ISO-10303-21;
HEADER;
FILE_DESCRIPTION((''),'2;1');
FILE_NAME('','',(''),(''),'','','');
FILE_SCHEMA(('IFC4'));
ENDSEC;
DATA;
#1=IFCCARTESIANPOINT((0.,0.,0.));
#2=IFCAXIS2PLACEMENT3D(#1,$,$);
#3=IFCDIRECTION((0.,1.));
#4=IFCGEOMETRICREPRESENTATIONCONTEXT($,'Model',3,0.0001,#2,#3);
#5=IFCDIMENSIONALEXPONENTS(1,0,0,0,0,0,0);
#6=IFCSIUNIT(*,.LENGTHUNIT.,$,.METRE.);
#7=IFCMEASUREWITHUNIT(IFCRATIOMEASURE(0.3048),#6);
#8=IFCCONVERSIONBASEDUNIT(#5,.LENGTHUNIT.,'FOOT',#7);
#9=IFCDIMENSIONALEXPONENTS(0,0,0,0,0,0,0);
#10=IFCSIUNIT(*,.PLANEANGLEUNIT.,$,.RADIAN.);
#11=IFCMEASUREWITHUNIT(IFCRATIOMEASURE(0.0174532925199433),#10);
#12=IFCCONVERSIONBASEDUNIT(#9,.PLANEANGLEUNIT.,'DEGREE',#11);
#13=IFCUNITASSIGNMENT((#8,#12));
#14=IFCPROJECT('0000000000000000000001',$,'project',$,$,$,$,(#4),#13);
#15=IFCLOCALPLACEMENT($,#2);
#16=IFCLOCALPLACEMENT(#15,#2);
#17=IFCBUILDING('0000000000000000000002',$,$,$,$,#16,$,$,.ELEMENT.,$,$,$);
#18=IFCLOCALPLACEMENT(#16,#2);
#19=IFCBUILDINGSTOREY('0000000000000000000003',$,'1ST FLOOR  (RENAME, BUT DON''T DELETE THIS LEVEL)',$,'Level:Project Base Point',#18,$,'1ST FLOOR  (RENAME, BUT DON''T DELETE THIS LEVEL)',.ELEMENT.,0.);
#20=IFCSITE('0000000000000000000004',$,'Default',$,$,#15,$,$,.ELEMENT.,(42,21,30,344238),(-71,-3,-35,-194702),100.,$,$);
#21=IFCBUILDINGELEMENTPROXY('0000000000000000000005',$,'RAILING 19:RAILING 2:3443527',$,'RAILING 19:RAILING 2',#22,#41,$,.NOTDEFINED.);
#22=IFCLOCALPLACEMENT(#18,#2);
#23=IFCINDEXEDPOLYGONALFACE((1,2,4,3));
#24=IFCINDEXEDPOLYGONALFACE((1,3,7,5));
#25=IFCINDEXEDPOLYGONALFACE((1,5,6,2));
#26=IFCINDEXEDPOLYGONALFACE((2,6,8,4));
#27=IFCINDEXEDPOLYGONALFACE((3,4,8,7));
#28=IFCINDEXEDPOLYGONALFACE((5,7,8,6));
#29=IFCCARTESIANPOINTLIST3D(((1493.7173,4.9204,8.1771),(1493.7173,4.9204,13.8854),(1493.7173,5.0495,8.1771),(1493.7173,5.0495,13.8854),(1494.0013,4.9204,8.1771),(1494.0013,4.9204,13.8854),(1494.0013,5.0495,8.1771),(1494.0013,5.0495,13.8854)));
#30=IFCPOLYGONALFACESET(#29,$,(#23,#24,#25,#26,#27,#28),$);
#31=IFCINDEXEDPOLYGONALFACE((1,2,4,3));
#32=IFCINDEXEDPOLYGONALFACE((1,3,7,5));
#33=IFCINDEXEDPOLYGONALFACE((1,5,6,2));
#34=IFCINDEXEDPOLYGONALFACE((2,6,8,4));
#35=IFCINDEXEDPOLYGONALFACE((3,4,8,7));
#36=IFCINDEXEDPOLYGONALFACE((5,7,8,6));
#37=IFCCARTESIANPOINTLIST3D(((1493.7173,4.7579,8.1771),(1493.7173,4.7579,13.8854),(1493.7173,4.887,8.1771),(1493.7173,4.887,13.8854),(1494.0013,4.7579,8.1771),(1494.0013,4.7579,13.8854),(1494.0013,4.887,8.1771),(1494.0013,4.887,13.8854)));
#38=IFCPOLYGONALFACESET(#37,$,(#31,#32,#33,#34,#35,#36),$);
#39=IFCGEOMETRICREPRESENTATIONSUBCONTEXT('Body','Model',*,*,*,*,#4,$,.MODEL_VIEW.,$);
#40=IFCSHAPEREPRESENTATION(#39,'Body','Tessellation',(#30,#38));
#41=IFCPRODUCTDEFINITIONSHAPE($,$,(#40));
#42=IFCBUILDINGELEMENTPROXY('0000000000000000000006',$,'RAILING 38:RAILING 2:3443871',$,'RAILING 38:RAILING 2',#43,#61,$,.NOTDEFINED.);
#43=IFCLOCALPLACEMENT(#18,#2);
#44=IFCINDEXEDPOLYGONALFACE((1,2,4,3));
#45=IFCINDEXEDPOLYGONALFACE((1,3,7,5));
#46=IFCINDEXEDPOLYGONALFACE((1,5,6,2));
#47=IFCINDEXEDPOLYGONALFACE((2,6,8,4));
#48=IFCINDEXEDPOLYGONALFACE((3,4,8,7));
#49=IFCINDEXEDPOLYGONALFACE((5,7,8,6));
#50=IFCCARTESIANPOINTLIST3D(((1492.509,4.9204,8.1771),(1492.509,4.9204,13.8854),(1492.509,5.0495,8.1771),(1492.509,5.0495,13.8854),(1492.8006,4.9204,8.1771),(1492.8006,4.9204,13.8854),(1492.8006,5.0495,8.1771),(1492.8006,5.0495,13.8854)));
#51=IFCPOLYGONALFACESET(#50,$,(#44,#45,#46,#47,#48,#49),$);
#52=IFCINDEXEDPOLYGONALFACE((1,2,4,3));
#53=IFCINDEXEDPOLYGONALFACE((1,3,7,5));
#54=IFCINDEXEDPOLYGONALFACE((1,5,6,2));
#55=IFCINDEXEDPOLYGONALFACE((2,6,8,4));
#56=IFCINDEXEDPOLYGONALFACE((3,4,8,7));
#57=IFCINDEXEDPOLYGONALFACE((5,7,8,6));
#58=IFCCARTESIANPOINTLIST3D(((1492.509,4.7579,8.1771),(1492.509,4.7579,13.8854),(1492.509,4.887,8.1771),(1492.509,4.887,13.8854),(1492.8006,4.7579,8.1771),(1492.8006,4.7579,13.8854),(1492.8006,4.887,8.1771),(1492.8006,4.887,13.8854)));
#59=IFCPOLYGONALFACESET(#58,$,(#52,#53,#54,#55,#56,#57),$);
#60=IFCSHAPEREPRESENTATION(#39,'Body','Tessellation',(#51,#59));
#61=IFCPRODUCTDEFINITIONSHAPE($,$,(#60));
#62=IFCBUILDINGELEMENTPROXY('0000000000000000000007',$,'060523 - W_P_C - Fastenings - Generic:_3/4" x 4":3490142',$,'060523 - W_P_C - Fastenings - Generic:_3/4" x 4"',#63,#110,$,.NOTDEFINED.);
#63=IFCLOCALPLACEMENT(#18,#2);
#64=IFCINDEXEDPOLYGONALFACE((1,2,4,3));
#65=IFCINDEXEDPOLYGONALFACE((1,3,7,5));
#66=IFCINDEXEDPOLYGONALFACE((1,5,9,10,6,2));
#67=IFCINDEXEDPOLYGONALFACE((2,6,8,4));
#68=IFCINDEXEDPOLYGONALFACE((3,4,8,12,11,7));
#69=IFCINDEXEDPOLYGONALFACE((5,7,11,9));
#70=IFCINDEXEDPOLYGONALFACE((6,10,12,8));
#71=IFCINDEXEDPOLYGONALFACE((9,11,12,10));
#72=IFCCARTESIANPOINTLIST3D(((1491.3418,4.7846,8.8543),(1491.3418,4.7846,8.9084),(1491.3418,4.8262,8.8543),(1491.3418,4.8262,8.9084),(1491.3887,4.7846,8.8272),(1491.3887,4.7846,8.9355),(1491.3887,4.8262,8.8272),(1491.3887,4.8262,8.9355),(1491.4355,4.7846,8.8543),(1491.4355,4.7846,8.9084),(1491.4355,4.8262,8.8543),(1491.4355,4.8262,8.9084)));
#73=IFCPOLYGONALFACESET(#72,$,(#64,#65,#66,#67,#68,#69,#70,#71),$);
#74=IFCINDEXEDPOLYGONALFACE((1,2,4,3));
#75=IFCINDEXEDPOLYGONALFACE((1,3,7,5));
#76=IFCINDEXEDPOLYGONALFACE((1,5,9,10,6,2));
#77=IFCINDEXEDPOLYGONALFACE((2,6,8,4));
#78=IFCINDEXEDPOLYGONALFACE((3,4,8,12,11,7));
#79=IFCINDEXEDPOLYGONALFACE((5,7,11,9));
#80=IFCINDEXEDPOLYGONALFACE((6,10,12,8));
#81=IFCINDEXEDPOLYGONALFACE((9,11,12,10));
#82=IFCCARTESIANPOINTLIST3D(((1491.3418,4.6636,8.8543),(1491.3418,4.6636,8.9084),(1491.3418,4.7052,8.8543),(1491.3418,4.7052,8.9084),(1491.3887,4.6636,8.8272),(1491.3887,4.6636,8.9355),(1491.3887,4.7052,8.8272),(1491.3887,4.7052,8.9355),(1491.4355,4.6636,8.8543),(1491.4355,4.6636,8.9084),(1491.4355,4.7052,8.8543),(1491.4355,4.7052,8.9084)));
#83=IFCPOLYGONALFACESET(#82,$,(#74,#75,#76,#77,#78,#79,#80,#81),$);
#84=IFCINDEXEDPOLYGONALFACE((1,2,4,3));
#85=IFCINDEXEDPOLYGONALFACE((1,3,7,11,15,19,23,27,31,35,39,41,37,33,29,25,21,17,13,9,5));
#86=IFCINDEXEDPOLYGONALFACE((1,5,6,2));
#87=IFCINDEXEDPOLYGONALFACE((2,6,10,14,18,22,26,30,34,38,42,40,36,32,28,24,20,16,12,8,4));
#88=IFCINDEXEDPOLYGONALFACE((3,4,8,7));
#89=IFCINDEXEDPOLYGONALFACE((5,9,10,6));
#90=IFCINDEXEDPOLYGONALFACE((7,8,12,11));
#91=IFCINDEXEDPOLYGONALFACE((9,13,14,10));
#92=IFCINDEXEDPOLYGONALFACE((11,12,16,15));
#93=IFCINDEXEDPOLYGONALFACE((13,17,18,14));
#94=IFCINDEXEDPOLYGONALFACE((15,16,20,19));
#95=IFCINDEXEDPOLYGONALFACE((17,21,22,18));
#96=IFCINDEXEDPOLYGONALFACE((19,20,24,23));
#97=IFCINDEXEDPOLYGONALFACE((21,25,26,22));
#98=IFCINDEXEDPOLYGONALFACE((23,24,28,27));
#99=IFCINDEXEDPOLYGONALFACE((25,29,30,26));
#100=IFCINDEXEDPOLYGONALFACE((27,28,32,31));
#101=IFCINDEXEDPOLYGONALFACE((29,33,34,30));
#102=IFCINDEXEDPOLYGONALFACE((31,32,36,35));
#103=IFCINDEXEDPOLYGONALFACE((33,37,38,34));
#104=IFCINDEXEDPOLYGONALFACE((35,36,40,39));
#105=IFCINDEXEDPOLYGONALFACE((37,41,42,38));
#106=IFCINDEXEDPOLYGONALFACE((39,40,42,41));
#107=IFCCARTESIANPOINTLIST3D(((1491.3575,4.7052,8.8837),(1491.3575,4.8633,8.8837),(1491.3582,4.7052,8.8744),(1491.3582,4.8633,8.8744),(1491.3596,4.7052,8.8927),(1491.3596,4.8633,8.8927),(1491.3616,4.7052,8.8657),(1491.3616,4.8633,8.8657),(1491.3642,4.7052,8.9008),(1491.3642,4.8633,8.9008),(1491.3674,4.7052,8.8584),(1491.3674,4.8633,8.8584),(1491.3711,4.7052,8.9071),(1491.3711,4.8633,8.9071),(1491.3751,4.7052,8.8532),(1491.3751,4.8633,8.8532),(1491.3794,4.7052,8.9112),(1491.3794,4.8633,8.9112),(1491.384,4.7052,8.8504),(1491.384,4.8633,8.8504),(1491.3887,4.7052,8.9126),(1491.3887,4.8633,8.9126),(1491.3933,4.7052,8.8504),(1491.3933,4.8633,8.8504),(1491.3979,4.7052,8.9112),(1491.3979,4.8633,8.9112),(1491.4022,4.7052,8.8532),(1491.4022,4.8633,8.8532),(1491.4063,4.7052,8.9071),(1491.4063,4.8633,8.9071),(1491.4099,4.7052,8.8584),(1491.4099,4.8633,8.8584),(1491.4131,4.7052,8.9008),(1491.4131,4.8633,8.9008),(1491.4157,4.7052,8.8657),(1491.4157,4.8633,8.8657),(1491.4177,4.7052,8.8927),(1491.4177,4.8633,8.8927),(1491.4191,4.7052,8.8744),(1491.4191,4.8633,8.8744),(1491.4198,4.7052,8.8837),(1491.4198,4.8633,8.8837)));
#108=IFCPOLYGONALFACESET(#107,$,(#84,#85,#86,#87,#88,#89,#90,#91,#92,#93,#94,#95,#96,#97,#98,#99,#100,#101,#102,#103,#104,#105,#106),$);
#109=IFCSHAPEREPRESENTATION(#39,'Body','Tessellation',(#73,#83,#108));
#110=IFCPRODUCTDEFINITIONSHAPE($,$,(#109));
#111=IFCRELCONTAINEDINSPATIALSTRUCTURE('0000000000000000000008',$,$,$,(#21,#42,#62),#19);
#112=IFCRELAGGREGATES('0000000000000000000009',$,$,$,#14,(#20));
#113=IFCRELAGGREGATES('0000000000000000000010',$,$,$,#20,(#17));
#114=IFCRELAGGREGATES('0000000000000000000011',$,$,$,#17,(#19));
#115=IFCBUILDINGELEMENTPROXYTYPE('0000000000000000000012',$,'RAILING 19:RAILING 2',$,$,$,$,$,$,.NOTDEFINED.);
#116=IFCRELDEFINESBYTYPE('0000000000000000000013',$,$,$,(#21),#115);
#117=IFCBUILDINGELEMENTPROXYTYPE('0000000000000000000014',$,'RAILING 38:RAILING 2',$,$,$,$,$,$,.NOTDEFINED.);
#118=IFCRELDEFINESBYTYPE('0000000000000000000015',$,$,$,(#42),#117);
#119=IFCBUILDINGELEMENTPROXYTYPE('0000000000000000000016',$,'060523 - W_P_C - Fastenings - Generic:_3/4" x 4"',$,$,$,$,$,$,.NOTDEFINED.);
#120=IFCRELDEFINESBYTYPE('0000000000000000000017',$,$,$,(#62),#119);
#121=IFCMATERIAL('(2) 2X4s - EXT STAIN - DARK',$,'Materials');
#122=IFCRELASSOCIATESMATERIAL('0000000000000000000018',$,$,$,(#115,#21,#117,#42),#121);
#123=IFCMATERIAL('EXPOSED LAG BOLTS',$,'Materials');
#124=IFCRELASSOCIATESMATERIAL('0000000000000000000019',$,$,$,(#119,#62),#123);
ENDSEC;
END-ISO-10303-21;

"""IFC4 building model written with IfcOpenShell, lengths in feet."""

from ifc_helpers import new_model, entity, si_unit, converted_unit, direction, frame, frame_2d, origin, place, context, subcontext, project, spatial, polyline, rectangle, circle, outline, extrude, source, transform, mapped, material, type_object, type_shapes, element, save


model = new_model("IFC4")

# Units and contexts
model_context = context("Model", 3, precision=0.0001, world=origin(), true_north=direction((0.0, 1.0)))
body_context = subcontext(model_context, "Body", "Model", "MODEL_VIEW")
ifc_project = project(units=[converted_unit("LENGTHUNIT", "FOOT", entity("IfcRatioMeasure", 0.3048), si_unit("LENGTHUNIT", "METRE"), dimensions=[1, 0, 0, 0, 0, 0, 0]), converted_unit("PLANEANGLEUNIT", "DEGREE", entity("IfcRatioMeasure", 0.0174532925199433), si_unit("PLANEANGLEUNIT", "RADIAN"), dimensions=[0, 0, 0, 0, 0, 0, 0])], contexts=[model_context])

# Site, building, storey
site_placement = place(None, origin())
site = spatial("IfcSite", under=ifc_project, at=site_placement, Name="Default", CompositionType="ELEMENT", RefLatitude=(42, 21, 30, 344238), RefLongitude=(-71, -3, -35, -194702), RefElevation=100.0)
building_placement = place(site_placement, origin())
building = spatial("IfcBuilding", under=site, at=building_placement, CompositionType="ELEMENT")
storey_placement = place(building_placement, origin())
storey = spatial("IfcBuildingStorey", under=building, at=storey_placement, Name="1ST FLOOR  (RENAME, BUT DON'T DELETE THIS LEVEL)", ObjectType="Level:Project Base Point", LongName="1ST FLOOR  (RENAME, BUT DON'T DELETE THIS LEVEL)", CompositionType="ELEMENT", Elevation=0.0)

# Building element proxies
ifc_material_1 = material(Name="(2) 2X4s - EXT STAIN - DARK", Category="Materials")
building_element_proxy_type_1 = type_object("IfcBuildingElementProxyType", Name="RAILING 19:RAILING 2", PredefinedType="NOTDEFINED", material=ifc_material_1)
shared_shape_1 = source(origin(), body_context, "Body", "SweptSolid", [
    extrude(rectangle(XDim=0.284, YDim=0.1292, at=frame_2d((0.0, 0.0), x_axis=(1.0, 0.0))), frame((0.142, 0.2271, 0.0), z_axis=(0.0, 0.0, 1.0), x_axis=(-1.0, 0.0, 0.0)), (0.0, 0.0, 1.0), 5.7083),
    extrude(rectangle(XDim=0.1292, YDim=0.284, at=frame_2d((0.0, 0.0), x_axis=(1.0, 0.0))), frame((0.142, 0.0646, 0.0), z_axis=(0.0, 0.0, 1.0), x_axis=(0.0, 1.0, 0.0)), (0.0, 0.0, 1.0), 5.7083),
])
type_shapes(building_element_proxy_type_1, [shared_shape_1])
proxy_1_placement = place(storey_placement, frame((1493.7173, 4.7579, 8.1771)))
element("IfcBuildingElementProxy", 1, at=proxy_1_placement, inside=storey, type_object=building_element_proxy_type_1, material=ifc_material_1, Name="RAILING 19:RAILING 2:3443527", ObjectType="RAILING 19:RAILING 2", PredefinedType="NOTDEFINED", context=body_context, shape_type="MappedRepresentation", body=[
    mapped(shared_shape_1, transform((0.0, 0.0, 0.0), scale=1.0)),
])
building_element_proxy_type_2 = type_object("IfcBuildingElementProxyType", Name="RAILING 38:RAILING 2", PredefinedType="NOTDEFINED", material=ifc_material_1)
shared_shape_2 = source(origin(), body_context, "Body", "SweptSolid", [
    extrude(rectangle(XDim=0.2917, YDim=0.1292, at=frame_2d((0.0, 0.0), x_axis=(1.0, 0.0))), frame((0.1458, 0.2271, 0.0), z_axis=(0.0, 0.0, 1.0), x_axis=(-1.0, 0.0, 0.0)), (0.0, 0.0, 1.0), 5.7083),
    extrude(rectangle(XDim=0.1292, YDim=0.2917, at=frame_2d((0.0, 0.0), x_axis=(1.0, 0.0))), frame((0.1458, 0.0646, 0.0), z_axis=(0.0, 0.0, 1.0), x_axis=(0.0, 1.0, 0.0)), (0.0, 0.0, 1.0), 5.7083),
])
type_shapes(building_element_proxy_type_2, [shared_shape_2])
proxy_2_placement = place(storey_placement, frame((1492.509, 4.7579, 8.1771)))
element("IfcBuildingElementProxy", 2, at=proxy_2_placement, inside=storey, type_object=building_element_proxy_type_2, material=ifc_material_1, Name="RAILING 38:RAILING 2:3443871", ObjectType="RAILING 38:RAILING 2", PredefinedType="NOTDEFINED", context=body_context, shape_type="MappedRepresentation", body=[
    mapped(shared_shape_2, transform((0.0, 0.0, 0.0), scale=1.0)),
])
ifc_material_2 = material(Name="EXPOSED LAG BOLTS", Category="Materials")
building_element_proxy_type_3 = type_object("IfcBuildingElementProxyType", Name="060523 - W_P_C - Fastenings - Generic:_3/4\" x 4\"", PredefinedType="NOTDEFINED", material=ifc_material_2)
shared_shape_3 = source(origin(), body_context, "Body", "SweptSolid", [
    extrude(outline(polyline([(-0.0271, -0.0469), (0.0271, -0.0469), (0.0541, 0.0), (0.0271, 0.0469), (-0.0271, 0.0469), (-0.0541, 0.0), (-0.0271, -0.0469)])), frame((0.0, 0.0, -0.121), z_axis=(0.0, 0.0, 1.0), x_axis=(0.866025, -0.5, 0.0)), (0.0, 0.0, 1.0), 0.0417),
    extrude(outline(polyline([(-0.0271, -0.0469), (0.0271, -0.0469), (0.0541, 0.0), (0.0271, 0.0469), (-0.0271, 0.0469), (-0.0541, 0.0), (-0.0271, -0.0469)])), frame((0.0, 0.0, 0.0), z_axis=(0.0, 0.0, 1.0), x_axis=(0.0, -1.0, 0.0)), (0.0, 0.0, 1.0), 0.0417),
    extrude(circle(Radius=0.0312, at=frame_2d((0.0, 0.0), x_axis=(1.0, 0.0))), frame((0.0, 0.0, -0.158), z_axis=(0.0, 0.0, 1.0), x_axis=(0.0, 1.0, 0.0)), (0.0, 0.0, 1.0), 0.158),
])
type_shapes(building_element_proxy_type_3, [shared_shape_3])
proxy_3_placement = place(storey_placement, frame((1491.3887, 4.7052, 8.8813), z_axis=(0.0, -1.0, 0.0), x_axis=(1.0, 0.0, 0.0)))
element("IfcBuildingElementProxy", 3, at=proxy_3_placement, inside=storey, type_object=building_element_proxy_type_3, material=ifc_material_2, Name="060523 - W_P_C - Fastenings - Generic:_3/4\" x 4\":3490142", ObjectType="060523 - W_P_C - Fastenings - Generic:_3/4\" x 4\"", PredefinedType="NOTDEFINED", context=body_context, shape_type="MappedRepresentation", body=[
    mapped(shared_shape_3, transform((0.0, 0.0, 0.0), scale=1.0)),
])

save(model, "model.ifc")
